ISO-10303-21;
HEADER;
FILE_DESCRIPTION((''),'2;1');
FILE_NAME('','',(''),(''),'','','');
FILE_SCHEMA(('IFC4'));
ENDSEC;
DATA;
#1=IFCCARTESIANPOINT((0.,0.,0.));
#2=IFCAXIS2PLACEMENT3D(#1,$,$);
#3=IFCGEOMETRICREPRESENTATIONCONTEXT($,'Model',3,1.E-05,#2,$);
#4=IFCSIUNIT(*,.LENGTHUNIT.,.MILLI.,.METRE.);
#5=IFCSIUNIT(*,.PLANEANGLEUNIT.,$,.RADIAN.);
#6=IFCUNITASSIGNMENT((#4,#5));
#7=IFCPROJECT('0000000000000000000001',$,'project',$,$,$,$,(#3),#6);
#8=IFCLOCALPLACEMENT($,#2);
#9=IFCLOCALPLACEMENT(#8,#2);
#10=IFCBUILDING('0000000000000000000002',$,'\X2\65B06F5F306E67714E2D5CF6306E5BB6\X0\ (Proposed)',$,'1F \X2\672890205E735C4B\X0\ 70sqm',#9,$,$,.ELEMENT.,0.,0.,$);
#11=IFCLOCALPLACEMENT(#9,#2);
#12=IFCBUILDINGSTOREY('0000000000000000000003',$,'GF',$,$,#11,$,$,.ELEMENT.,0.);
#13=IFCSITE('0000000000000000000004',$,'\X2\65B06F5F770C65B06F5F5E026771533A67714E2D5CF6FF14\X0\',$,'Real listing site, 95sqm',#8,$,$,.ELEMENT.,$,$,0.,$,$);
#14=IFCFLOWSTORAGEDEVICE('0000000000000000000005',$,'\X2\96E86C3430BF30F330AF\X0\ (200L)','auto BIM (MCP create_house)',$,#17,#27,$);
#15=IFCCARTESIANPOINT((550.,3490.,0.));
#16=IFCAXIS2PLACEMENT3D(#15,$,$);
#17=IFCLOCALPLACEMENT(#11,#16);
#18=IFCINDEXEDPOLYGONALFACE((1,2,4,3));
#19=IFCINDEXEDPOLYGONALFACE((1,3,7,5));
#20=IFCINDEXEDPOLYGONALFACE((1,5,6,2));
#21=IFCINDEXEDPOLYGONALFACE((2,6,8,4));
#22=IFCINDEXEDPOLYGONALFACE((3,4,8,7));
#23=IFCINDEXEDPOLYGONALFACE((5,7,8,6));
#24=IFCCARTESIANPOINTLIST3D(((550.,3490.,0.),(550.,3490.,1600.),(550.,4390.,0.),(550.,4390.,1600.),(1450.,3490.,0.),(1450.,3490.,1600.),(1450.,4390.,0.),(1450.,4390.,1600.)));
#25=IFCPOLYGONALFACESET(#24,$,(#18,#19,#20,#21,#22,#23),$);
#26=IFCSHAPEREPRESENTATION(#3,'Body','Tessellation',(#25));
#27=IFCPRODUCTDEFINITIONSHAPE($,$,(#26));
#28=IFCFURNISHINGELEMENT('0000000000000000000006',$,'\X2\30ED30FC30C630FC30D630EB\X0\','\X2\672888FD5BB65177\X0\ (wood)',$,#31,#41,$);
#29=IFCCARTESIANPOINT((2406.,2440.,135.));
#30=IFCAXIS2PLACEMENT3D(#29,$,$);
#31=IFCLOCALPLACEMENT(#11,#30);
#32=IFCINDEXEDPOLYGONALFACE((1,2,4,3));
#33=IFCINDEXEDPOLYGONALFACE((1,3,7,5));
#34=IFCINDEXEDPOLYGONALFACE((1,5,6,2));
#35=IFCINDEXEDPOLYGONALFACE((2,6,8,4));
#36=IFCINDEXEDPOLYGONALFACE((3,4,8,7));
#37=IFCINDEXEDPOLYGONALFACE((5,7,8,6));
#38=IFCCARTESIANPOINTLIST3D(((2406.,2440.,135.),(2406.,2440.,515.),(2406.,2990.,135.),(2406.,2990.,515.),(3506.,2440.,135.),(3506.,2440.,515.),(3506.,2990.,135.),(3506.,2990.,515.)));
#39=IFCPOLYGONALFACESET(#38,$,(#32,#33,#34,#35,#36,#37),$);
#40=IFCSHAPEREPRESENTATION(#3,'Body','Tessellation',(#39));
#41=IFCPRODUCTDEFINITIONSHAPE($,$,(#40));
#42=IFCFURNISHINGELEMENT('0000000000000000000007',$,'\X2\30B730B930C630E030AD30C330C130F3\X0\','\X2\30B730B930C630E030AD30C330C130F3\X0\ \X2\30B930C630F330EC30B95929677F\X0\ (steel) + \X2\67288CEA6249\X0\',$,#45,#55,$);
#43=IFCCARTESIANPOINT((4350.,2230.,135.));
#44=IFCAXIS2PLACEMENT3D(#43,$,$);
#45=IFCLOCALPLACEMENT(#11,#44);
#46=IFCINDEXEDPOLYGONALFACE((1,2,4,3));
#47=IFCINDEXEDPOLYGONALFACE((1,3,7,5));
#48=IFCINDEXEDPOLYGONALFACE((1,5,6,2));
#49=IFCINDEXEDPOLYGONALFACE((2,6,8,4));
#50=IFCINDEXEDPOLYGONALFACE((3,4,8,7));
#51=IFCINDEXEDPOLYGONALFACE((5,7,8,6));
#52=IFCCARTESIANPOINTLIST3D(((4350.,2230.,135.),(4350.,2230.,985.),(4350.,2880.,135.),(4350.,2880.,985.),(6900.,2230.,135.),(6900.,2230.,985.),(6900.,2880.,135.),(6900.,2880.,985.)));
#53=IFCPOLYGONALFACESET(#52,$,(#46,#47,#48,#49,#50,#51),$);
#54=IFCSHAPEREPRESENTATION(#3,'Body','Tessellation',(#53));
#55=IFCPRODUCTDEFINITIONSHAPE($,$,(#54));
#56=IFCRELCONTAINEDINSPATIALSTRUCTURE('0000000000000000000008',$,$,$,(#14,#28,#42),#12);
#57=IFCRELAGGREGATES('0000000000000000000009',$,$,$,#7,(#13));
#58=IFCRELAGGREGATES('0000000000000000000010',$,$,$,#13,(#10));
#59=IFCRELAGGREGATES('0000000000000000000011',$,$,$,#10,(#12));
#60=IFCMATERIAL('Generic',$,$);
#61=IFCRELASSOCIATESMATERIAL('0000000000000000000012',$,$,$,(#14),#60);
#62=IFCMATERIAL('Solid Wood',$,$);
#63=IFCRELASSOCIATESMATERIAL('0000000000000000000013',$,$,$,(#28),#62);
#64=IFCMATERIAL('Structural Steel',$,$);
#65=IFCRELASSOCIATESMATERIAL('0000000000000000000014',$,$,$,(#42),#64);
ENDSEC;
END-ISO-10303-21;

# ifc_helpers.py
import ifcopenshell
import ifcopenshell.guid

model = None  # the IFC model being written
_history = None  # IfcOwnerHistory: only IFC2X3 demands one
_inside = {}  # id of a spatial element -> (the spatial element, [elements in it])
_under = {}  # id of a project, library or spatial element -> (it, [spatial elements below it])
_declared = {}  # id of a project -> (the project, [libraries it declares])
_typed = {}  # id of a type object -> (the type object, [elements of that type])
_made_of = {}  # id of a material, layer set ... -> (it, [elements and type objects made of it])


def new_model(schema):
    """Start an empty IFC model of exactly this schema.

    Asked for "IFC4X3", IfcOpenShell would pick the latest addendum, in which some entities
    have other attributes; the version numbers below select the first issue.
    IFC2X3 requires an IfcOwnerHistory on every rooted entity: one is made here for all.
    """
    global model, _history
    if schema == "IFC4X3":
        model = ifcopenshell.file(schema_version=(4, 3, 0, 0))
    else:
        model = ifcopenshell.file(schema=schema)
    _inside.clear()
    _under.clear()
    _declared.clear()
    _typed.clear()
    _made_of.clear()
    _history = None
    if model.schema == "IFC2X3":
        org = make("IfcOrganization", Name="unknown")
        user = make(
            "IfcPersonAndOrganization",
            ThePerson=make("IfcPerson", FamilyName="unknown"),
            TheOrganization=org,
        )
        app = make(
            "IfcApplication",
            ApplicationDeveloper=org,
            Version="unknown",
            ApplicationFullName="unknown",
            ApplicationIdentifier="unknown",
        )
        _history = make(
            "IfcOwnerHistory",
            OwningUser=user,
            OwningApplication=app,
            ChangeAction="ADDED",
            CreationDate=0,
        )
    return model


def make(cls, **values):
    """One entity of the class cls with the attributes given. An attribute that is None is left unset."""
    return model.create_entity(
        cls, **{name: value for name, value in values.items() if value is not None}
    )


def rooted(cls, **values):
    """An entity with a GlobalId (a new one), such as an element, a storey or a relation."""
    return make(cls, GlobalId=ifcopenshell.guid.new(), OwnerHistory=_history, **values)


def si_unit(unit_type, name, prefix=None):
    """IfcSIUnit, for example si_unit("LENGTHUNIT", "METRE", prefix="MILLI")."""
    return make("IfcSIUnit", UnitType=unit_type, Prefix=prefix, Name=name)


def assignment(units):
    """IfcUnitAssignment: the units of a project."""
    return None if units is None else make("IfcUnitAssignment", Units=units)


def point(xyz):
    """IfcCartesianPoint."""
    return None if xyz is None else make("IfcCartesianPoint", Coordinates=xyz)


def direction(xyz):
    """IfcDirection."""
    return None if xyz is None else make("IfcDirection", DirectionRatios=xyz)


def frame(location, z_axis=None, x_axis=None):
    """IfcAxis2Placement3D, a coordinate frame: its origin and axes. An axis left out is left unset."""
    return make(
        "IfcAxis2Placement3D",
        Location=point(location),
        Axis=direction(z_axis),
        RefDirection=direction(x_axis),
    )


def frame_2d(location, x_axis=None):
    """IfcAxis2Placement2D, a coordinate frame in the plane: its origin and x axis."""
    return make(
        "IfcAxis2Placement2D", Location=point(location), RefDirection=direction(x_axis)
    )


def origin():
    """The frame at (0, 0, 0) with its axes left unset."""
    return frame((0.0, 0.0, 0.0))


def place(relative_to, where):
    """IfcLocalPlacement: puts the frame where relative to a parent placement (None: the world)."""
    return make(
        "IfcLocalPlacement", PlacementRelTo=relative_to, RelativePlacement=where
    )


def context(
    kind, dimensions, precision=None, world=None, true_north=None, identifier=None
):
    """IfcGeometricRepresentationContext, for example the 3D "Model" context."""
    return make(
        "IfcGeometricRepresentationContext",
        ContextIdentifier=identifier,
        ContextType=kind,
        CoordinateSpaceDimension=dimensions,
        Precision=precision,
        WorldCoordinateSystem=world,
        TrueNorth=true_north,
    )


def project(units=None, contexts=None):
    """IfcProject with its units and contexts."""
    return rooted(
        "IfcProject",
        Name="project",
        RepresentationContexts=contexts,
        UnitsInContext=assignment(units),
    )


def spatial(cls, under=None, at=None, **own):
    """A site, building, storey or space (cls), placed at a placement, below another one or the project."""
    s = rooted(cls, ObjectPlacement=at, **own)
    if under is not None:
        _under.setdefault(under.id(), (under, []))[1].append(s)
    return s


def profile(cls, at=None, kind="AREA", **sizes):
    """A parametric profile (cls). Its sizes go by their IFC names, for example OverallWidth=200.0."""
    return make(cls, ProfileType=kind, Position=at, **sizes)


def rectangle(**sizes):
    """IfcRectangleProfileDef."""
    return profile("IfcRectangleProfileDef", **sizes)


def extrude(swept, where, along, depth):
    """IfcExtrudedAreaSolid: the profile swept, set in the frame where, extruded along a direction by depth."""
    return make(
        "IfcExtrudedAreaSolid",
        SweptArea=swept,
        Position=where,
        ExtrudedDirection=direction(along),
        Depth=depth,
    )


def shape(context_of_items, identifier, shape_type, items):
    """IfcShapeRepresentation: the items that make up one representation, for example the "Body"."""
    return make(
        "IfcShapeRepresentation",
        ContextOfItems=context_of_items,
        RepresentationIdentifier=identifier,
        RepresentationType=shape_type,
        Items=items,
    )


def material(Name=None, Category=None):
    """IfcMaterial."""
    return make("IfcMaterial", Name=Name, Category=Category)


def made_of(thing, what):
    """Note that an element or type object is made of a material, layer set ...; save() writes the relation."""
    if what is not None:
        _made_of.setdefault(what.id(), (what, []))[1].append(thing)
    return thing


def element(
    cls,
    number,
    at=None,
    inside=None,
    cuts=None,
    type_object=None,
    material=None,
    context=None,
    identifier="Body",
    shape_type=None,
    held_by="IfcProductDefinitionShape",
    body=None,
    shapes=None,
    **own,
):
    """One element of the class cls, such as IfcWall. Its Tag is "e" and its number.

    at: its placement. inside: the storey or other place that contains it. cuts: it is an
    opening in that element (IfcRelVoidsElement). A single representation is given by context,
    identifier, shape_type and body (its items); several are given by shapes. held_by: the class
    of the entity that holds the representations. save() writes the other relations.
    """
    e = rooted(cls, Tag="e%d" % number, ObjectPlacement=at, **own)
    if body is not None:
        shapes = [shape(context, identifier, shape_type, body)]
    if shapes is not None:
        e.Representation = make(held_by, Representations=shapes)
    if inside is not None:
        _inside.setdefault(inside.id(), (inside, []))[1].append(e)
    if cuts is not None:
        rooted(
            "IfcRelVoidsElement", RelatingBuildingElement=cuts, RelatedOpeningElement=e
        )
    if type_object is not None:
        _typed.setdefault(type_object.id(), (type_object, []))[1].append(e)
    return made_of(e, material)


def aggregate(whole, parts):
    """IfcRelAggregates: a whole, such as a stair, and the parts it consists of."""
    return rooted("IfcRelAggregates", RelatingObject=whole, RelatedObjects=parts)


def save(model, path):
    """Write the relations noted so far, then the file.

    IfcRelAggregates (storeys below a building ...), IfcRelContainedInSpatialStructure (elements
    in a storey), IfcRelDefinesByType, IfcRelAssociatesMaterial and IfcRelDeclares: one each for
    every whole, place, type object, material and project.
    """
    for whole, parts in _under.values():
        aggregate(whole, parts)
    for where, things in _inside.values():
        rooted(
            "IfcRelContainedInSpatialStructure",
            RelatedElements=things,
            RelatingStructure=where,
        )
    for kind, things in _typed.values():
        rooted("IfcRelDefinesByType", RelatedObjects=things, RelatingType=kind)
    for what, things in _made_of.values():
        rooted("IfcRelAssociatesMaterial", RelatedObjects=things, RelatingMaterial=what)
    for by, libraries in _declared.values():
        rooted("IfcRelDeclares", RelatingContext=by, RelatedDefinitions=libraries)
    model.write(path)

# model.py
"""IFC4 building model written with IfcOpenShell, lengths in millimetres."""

from ifc_helpers import new_model, si_unit, frame, frame_2d, origin, place, context, project, spatial, rectangle, extrude, material, element, save


model = new_model("IFC4")

# Units and contexts
model_context = context("Model", 3, precision=1e-05, world=origin())
ifc_project = project(units=[si_unit("LENGTHUNIT", "METRE", prefix="MILLI"), si_unit("PLANEANGLEUNIT", "RADIAN")], contexts=[model_context])

# Site, building, storey
site_placement = place(None, origin())
site = spatial("IfcSite", under=ifc_project, at=site_placement, Name="新潟県新潟市東区東中島４", ObjectType="Real listing site, 95sqm", CompositionType="ELEMENT", RefElevation=0.0)
building_placement = place(site_placement, origin())
building = spatial("IfcBuilding", under=site, at=building_placement, Name="新潟の東中島の家 (Proposed)", ObjectType="1F 木造平屋 70sqm", CompositionType="ELEMENT", ElevationOfRefHeight=0.0, ElevationOfTerrain=0.0)
storey_placement = place(building_placement, origin())
storey = spatial("IfcBuildingStorey", under=building, at=storey_placement, Name="GF", CompositionType="ELEMENT", Elevation=0.0)

# Shared definitions
ifc_material_1 = material(Name="Solid Wood")

# Shared definitions
ifc_material_2 = material(Name="Generic")

# Flow storage device
flow_storage_device_placement = place(storey_placement, frame((550.0, 3490.0, 0.0)))
element("IfcFlowStorageDevice", 1, at=flow_storage_device_placement, inside=storey, material=ifc_material_2, Name="雨水タンク (200L)", Description="auto BIM (MCP create_house)", context=model_context, shape_type="SweptSolid", body=[
    extrude(rectangle(XDim=900.0, YDim=900.0, at=frame_2d((450.0, 450.0))), frame((550.0, 3490.0, 0.0)), (0.0, 0.0, 1.0), 1600.0),
])

# Furnishing elements
furnishing_1_placement = place(storey_placement, frame((2406.0, 2440.0, 135.0)))
element("IfcFurnishingElement", 2, at=furnishing_1_placement, inside=storey, material=ifc_material_1, Name="ローテーブル", Description="木製家具 (wood)", context=model_context, shape_type="SweptSolid", body=[
    extrude(rectangle(XDim=1100.0, YDim=550.0, at=frame_2d((550.0, 275.0))), frame((2406.0, 2440.0, 135.0)), (0.0, 0.0, 1.0), 380.0),
])
ifc_material_3 = material(Name="Structural Steel")
furnishing_2_placement = place(storey_placement, frame((4350.0, 2230.0, 135.0)))
element("IfcFurnishingElement", 3, at=furnishing_2_placement, inside=storey, material=ifc_material_3, Name="システムキッチン", Description="システムキッチン ステンレス天板 (steel) + 木質扉", context=model_context, shape_type="SweptSolid", body=[
    extrude(rectangle(XDim=2550.0, YDim=650.0, at=frame_2d((1275.0, 325.0))), frame((4350.0, 2230.0, 135.0)), (0.0, 0.0, 1.0), 850.0),
])

save(model, "model.ifc")
